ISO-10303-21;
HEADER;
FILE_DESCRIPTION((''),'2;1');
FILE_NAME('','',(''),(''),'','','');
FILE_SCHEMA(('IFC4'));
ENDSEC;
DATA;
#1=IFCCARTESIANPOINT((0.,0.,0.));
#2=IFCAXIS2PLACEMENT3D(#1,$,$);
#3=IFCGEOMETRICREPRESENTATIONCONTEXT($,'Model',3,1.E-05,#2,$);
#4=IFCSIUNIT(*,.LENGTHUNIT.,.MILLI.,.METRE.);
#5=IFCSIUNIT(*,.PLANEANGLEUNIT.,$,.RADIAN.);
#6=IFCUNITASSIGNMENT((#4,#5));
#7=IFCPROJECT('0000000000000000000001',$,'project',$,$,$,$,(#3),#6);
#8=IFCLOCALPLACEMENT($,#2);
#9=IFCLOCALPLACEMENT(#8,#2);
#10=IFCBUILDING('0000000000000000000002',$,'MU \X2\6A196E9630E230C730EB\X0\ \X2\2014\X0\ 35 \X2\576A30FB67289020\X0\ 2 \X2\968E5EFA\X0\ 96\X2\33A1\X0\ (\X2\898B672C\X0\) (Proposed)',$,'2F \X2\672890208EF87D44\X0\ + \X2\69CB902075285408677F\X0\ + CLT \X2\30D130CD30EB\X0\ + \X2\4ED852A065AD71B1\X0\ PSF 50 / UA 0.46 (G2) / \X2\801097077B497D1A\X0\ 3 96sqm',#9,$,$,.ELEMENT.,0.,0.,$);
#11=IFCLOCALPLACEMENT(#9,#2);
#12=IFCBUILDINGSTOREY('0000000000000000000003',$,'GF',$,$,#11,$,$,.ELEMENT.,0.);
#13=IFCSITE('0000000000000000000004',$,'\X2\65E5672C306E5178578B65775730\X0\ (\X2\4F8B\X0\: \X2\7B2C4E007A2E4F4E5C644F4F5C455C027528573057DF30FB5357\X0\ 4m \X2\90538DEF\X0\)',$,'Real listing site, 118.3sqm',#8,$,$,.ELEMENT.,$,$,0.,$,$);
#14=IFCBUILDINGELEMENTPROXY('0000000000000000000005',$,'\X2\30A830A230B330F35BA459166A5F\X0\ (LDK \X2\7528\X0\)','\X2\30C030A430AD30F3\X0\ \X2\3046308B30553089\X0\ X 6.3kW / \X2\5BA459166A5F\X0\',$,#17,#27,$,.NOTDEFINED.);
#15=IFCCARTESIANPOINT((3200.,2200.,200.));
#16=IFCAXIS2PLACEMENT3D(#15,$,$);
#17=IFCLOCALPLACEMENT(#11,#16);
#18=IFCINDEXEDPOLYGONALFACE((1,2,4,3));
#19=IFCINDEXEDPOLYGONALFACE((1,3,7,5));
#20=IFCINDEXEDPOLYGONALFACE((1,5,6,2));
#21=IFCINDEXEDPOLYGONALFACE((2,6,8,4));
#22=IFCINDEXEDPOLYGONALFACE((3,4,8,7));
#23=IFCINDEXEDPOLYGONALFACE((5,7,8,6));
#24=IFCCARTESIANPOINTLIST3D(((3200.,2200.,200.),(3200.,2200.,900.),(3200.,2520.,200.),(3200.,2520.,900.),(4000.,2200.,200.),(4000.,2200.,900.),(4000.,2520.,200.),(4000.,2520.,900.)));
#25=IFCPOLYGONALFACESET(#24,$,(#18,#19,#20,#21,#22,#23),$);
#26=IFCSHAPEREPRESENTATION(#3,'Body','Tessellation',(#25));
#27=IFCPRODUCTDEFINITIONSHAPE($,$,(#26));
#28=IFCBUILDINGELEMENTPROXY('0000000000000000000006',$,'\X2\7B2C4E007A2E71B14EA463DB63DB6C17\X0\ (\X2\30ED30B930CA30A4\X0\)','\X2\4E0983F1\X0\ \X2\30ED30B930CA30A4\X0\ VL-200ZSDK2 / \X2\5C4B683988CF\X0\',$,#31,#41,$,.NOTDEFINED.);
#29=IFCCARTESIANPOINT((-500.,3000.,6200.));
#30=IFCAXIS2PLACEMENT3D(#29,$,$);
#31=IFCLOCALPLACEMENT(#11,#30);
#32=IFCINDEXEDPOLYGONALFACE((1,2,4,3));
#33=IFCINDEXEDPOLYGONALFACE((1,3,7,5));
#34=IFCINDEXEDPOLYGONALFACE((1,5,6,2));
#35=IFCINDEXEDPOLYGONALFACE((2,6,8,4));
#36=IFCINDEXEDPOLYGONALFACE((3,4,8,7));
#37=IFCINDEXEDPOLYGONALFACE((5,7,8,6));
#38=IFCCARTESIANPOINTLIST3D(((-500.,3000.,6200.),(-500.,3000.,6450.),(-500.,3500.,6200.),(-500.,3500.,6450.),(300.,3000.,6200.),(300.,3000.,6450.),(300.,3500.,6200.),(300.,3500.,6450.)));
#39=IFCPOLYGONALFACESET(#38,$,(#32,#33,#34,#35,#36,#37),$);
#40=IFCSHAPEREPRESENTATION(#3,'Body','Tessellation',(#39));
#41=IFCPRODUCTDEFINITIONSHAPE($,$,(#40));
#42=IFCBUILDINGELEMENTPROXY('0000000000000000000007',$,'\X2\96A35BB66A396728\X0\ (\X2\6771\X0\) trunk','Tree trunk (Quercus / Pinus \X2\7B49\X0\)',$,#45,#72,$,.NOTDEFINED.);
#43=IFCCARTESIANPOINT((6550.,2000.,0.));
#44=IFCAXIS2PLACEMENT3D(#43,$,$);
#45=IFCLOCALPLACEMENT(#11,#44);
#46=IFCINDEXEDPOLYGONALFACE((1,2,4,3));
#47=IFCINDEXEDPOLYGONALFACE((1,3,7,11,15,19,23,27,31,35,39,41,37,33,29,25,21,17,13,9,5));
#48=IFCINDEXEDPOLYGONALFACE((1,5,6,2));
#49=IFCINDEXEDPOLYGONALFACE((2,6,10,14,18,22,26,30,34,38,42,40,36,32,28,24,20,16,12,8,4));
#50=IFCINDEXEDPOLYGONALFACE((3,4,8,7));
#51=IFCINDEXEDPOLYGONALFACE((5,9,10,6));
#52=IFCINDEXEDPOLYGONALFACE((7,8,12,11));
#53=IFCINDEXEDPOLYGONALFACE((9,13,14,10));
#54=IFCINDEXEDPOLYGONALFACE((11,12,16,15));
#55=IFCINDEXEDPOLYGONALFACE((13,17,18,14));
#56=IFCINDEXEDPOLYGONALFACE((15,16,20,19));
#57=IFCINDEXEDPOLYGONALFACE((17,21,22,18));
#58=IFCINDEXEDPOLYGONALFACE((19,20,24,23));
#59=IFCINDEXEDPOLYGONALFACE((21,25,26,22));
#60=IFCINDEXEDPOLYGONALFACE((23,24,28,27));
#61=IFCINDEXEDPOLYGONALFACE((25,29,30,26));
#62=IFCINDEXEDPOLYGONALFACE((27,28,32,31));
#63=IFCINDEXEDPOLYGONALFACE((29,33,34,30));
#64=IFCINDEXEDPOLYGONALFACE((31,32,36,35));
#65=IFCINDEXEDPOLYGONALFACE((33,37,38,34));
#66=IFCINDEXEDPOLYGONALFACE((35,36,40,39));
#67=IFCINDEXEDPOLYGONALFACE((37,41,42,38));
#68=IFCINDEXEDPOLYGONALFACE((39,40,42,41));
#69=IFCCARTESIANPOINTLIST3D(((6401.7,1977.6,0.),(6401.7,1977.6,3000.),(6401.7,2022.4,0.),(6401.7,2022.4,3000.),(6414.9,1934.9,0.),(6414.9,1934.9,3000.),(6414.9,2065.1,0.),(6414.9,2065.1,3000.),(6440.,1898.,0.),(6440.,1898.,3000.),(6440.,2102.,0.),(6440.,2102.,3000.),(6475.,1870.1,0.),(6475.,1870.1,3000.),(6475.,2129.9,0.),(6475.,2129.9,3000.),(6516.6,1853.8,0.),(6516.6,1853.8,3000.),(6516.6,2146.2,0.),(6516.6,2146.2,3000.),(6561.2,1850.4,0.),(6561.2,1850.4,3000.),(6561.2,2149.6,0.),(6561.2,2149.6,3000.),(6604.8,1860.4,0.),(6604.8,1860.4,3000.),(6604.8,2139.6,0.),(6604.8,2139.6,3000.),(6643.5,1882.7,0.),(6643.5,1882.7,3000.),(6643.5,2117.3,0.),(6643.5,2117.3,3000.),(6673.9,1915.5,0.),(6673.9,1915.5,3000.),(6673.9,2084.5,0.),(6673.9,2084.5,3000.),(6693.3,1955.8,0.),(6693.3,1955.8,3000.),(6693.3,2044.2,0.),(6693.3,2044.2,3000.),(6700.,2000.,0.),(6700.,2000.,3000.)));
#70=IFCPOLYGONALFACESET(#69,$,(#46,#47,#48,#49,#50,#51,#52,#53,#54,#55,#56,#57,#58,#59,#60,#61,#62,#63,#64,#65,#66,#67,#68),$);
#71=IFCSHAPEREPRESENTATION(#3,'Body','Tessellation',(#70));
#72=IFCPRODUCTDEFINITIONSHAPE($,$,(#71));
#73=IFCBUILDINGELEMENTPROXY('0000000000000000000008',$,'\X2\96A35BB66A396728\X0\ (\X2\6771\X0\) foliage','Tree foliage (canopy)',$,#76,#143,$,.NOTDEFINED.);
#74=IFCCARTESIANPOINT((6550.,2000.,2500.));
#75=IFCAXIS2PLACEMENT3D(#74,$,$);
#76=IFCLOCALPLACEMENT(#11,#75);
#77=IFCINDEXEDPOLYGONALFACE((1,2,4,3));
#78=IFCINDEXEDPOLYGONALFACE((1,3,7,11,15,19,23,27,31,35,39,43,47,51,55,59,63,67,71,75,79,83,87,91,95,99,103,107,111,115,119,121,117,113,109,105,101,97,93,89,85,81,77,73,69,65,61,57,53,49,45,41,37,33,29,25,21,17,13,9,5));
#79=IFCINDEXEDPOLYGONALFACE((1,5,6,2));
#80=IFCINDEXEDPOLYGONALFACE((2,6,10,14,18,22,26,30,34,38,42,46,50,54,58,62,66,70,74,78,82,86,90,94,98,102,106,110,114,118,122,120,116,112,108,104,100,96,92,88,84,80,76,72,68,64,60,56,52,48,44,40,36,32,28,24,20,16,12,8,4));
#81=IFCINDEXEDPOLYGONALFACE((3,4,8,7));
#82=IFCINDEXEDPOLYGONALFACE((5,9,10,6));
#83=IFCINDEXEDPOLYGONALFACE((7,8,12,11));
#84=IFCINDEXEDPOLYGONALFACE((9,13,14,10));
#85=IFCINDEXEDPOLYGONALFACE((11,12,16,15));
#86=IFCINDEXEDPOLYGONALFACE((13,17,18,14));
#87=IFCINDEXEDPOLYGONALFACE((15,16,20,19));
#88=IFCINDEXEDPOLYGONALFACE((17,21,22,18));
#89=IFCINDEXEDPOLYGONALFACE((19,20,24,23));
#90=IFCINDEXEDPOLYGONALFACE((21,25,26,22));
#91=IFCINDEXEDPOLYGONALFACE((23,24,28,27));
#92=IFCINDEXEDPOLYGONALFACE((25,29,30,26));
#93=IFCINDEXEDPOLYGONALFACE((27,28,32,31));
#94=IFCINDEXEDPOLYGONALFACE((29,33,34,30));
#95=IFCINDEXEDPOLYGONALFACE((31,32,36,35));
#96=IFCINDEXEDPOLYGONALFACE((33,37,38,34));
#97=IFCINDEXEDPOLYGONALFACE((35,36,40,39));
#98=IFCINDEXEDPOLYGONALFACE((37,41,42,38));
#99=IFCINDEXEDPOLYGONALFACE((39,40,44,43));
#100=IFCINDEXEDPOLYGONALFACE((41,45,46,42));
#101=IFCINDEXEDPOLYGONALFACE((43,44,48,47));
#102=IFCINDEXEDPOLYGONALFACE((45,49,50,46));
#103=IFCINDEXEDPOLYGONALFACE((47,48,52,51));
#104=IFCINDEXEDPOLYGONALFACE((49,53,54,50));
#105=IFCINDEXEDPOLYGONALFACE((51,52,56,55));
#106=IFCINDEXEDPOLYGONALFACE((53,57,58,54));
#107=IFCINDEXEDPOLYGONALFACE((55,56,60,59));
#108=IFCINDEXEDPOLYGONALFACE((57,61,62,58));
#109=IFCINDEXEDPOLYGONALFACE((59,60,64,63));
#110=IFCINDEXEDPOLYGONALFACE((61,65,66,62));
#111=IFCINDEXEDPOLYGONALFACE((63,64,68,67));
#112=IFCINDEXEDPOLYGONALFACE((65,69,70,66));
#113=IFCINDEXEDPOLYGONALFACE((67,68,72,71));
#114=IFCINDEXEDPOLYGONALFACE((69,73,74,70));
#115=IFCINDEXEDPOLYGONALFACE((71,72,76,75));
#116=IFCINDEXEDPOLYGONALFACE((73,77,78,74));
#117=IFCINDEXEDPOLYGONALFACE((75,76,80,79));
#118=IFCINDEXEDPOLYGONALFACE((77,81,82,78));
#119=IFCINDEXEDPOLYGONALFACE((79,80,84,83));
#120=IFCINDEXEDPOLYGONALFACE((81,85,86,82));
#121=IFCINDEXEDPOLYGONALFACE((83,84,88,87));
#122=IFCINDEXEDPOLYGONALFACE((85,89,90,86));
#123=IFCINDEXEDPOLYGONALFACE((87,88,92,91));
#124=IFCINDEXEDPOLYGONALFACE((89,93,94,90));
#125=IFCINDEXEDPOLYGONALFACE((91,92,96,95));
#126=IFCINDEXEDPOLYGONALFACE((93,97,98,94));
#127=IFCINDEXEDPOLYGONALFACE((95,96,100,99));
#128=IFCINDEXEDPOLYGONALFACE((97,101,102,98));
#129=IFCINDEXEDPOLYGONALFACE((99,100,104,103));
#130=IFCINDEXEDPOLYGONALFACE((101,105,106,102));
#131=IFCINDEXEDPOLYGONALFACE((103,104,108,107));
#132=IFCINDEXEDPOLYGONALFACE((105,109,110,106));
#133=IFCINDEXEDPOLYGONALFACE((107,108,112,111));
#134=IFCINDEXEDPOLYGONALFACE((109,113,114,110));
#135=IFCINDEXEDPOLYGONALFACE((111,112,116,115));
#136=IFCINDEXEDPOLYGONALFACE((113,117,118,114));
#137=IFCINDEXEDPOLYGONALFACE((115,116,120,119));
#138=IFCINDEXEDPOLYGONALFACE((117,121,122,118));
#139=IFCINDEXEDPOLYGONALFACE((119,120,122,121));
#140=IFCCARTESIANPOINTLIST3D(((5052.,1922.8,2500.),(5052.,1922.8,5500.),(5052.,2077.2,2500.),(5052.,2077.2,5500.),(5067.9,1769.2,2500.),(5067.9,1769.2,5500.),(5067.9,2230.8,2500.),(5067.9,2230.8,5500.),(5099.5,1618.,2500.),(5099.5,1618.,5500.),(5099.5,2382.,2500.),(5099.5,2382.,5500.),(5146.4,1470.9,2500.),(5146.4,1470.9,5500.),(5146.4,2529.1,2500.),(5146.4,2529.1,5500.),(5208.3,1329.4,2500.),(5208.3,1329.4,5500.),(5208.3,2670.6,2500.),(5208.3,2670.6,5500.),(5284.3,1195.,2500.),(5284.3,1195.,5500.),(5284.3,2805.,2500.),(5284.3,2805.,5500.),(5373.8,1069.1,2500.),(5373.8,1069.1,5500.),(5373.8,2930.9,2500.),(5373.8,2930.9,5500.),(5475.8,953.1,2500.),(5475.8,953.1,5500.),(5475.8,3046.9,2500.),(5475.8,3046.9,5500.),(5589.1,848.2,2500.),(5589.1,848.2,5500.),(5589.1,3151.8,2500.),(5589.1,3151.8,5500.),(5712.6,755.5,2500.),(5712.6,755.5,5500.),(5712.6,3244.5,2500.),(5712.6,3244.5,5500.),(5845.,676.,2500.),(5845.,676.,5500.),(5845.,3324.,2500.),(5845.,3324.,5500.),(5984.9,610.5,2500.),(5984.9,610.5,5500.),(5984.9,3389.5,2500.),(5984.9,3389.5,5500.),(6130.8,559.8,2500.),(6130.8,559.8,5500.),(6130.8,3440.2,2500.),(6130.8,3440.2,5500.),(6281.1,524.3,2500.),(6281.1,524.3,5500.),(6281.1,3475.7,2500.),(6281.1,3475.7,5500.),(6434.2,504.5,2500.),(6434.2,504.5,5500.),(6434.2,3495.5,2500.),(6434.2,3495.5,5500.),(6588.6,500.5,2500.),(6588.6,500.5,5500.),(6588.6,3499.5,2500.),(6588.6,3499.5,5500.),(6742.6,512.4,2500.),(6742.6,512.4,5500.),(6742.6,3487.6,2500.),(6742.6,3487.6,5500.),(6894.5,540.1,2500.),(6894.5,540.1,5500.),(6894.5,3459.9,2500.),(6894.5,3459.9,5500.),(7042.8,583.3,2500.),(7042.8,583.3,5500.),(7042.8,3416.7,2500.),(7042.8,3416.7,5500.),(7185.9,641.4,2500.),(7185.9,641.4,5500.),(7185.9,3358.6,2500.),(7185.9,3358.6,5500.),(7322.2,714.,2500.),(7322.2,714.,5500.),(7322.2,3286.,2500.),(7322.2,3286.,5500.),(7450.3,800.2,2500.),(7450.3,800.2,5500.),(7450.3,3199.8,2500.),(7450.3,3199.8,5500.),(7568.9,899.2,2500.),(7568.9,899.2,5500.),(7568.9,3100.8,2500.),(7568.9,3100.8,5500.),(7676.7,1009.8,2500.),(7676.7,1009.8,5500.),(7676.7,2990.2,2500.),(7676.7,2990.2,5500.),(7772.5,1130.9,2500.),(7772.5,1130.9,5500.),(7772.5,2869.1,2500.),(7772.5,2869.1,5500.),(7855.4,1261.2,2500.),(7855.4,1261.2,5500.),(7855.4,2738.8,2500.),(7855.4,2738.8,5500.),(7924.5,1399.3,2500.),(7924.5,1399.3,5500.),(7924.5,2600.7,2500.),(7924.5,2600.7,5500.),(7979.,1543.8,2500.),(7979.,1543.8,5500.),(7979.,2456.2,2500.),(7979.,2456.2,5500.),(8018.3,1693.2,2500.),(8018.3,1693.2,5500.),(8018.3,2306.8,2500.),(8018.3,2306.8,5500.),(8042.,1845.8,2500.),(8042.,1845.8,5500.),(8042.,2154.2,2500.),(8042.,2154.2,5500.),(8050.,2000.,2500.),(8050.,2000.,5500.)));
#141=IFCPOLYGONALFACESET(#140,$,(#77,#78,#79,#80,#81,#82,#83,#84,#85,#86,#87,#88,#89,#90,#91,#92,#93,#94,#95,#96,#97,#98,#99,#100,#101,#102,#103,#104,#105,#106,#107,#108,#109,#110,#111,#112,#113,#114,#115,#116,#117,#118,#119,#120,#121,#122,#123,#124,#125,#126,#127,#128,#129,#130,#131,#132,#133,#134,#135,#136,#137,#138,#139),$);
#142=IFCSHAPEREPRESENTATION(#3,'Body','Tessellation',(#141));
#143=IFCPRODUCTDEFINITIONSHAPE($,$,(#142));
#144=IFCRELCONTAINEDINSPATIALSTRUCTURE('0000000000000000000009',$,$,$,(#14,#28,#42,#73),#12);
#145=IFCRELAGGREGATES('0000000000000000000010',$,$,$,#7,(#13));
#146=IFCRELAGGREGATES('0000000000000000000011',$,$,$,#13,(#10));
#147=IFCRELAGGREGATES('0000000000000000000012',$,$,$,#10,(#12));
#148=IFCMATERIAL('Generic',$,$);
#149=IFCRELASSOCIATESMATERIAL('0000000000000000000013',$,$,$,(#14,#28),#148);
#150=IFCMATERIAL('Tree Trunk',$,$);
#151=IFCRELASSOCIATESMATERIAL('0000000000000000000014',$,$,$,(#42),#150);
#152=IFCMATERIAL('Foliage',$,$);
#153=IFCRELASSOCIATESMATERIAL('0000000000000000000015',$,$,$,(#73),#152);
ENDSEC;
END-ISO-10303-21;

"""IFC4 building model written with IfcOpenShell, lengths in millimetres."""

from ifc_helpers import new_model, si_unit, frame, frame_2d, origin, origin_2d, place, context, project, spatial, rectangle, circle, extrude, material, element, save


model = new_model("IFC4")

# Units and contexts
model_context = context("Model", 3, precision=1e-05, world=origin())
ifc_project = project(units=[si_unit("LENGTHUNIT", "METRE", prefix="MILLI"), si_unit("PLANEANGLEUNIT", "RADIAN")], contexts=[model_context])

# Site, building, storey
site_placement = place(None, origin())
site = spatial("IfcSite", under=ifc_project, at=site_placement, Name="日本の典型敷地 (例: 第一種低層住居専用地域・南 4m 道路)", ObjectType="Real listing site, 118.3sqm", CompositionType="ELEMENT", RefElevation=0.0)
building_placement = place(site_placement, origin())
building = spatial("IfcBuilding", under=site, at=building_placement, Name="MU 標準モデル — 35 坪・木造 2 階建 96㎡ (見本) (Proposed)", ObjectType="2F 木造軸組 + 構造用合板 + CLT パネル + 付加断熱 PSF 50 / UA 0.46 (G2) / 耐震等級 3 96sqm", CompositionType="ELEMENT", ElevationOfRefHeight=0.0, ElevationOfTerrain=0.0)
storey_placement = place(building_placement, origin())
storey = spatial("IfcBuildingStorey", under=building, at=storey_placement, Name="GF", CompositionType="ELEMENT", Elevation=0.0)

# Shared definitions
ifc_material_1 = material(Name="Generic")

# Building element proxies
proxy_1_placement = place(storey_placement, frame((3200.0, 2200.0, 200.0)))
element("IfcBuildingElementProxy", 1, at=proxy_1_placement, inside=storey, material=ifc_material_1, Name="エアコン室外機 (LDK 用)", Description="ダイキン うるさら X 6.3kW / 室外機", PredefinedType="NOTDEFINED", context=model_context, shape_type="SweptSolid", body=[
    extrude(rectangle(XDim=800.0, YDim=320.0, at=frame_2d((400.0, 160.0))), frame((3200.0, 2200.0, 200.0)), (0.0, 0.0, 1.0), 700.0),
])
proxy_2_placement = place(storey_placement, frame((-500.0, 3000.0, 6200.0)))
element("IfcBuildingElementProxy", 2, at=proxy_2_placement, inside=storey, material=ifc_material_1, Name="第一種熱交換換気 (ロスナイ)", Description="三菱 ロスナイ VL-200ZSDK2 / 屋根裏", PredefinedType="NOTDEFINED", context=model_context, shape_type="SweptSolid", body=[
    extrude(rectangle(XDim=800.0, YDim=500.0, at=frame_2d((400.0, 250.0))), frame((-500.0, 3000.0, 6200.0)), (0.0, 0.0, 1.0), 250.0),
])
ifc_material_2 = material(Name="Tree Trunk")
proxy_3_placement = place(storey_placement, frame((6550.0, 2000.0, 0.0)))
element("IfcBuildingElementProxy", 3, at=proxy_3_placement, inside=storey, material=ifc_material_2, Name="隣家樹木 (東) trunk", Description="Tree trunk (Quercus / Pinus 等)", PredefinedType="NOTDEFINED", context=model_context, shape_type="SweptSolid", body=[
    extrude(circle(Radius=150.0, at=origin_2d()), frame((6550.0, 2000.0, 0.0)), (0.0, 0.0, 1.0), 3000.0),
])
ifc_material_3 = material(Name="Foliage")
proxy_4_placement = place(storey_placement, frame((6550.0, 2000.0, 2500.0)))
element("IfcBuildingElementProxy", 4, at=proxy_4_placement, inside=storey, material=ifc_material_3, Name="隣家樹木 (東) foliage", Description="Tree foliage (canopy)", PredefinedType="NOTDEFINED", context=model_context, shape_type="SweptSolid", body=[
    extrude(circle(Radius=1500.0, at=origin_2d()), frame((6550.0, 2000.0, 2500.0)), (0.0, 0.0, 1.0), 3000.0),
])

save(model, "model.ifc")
